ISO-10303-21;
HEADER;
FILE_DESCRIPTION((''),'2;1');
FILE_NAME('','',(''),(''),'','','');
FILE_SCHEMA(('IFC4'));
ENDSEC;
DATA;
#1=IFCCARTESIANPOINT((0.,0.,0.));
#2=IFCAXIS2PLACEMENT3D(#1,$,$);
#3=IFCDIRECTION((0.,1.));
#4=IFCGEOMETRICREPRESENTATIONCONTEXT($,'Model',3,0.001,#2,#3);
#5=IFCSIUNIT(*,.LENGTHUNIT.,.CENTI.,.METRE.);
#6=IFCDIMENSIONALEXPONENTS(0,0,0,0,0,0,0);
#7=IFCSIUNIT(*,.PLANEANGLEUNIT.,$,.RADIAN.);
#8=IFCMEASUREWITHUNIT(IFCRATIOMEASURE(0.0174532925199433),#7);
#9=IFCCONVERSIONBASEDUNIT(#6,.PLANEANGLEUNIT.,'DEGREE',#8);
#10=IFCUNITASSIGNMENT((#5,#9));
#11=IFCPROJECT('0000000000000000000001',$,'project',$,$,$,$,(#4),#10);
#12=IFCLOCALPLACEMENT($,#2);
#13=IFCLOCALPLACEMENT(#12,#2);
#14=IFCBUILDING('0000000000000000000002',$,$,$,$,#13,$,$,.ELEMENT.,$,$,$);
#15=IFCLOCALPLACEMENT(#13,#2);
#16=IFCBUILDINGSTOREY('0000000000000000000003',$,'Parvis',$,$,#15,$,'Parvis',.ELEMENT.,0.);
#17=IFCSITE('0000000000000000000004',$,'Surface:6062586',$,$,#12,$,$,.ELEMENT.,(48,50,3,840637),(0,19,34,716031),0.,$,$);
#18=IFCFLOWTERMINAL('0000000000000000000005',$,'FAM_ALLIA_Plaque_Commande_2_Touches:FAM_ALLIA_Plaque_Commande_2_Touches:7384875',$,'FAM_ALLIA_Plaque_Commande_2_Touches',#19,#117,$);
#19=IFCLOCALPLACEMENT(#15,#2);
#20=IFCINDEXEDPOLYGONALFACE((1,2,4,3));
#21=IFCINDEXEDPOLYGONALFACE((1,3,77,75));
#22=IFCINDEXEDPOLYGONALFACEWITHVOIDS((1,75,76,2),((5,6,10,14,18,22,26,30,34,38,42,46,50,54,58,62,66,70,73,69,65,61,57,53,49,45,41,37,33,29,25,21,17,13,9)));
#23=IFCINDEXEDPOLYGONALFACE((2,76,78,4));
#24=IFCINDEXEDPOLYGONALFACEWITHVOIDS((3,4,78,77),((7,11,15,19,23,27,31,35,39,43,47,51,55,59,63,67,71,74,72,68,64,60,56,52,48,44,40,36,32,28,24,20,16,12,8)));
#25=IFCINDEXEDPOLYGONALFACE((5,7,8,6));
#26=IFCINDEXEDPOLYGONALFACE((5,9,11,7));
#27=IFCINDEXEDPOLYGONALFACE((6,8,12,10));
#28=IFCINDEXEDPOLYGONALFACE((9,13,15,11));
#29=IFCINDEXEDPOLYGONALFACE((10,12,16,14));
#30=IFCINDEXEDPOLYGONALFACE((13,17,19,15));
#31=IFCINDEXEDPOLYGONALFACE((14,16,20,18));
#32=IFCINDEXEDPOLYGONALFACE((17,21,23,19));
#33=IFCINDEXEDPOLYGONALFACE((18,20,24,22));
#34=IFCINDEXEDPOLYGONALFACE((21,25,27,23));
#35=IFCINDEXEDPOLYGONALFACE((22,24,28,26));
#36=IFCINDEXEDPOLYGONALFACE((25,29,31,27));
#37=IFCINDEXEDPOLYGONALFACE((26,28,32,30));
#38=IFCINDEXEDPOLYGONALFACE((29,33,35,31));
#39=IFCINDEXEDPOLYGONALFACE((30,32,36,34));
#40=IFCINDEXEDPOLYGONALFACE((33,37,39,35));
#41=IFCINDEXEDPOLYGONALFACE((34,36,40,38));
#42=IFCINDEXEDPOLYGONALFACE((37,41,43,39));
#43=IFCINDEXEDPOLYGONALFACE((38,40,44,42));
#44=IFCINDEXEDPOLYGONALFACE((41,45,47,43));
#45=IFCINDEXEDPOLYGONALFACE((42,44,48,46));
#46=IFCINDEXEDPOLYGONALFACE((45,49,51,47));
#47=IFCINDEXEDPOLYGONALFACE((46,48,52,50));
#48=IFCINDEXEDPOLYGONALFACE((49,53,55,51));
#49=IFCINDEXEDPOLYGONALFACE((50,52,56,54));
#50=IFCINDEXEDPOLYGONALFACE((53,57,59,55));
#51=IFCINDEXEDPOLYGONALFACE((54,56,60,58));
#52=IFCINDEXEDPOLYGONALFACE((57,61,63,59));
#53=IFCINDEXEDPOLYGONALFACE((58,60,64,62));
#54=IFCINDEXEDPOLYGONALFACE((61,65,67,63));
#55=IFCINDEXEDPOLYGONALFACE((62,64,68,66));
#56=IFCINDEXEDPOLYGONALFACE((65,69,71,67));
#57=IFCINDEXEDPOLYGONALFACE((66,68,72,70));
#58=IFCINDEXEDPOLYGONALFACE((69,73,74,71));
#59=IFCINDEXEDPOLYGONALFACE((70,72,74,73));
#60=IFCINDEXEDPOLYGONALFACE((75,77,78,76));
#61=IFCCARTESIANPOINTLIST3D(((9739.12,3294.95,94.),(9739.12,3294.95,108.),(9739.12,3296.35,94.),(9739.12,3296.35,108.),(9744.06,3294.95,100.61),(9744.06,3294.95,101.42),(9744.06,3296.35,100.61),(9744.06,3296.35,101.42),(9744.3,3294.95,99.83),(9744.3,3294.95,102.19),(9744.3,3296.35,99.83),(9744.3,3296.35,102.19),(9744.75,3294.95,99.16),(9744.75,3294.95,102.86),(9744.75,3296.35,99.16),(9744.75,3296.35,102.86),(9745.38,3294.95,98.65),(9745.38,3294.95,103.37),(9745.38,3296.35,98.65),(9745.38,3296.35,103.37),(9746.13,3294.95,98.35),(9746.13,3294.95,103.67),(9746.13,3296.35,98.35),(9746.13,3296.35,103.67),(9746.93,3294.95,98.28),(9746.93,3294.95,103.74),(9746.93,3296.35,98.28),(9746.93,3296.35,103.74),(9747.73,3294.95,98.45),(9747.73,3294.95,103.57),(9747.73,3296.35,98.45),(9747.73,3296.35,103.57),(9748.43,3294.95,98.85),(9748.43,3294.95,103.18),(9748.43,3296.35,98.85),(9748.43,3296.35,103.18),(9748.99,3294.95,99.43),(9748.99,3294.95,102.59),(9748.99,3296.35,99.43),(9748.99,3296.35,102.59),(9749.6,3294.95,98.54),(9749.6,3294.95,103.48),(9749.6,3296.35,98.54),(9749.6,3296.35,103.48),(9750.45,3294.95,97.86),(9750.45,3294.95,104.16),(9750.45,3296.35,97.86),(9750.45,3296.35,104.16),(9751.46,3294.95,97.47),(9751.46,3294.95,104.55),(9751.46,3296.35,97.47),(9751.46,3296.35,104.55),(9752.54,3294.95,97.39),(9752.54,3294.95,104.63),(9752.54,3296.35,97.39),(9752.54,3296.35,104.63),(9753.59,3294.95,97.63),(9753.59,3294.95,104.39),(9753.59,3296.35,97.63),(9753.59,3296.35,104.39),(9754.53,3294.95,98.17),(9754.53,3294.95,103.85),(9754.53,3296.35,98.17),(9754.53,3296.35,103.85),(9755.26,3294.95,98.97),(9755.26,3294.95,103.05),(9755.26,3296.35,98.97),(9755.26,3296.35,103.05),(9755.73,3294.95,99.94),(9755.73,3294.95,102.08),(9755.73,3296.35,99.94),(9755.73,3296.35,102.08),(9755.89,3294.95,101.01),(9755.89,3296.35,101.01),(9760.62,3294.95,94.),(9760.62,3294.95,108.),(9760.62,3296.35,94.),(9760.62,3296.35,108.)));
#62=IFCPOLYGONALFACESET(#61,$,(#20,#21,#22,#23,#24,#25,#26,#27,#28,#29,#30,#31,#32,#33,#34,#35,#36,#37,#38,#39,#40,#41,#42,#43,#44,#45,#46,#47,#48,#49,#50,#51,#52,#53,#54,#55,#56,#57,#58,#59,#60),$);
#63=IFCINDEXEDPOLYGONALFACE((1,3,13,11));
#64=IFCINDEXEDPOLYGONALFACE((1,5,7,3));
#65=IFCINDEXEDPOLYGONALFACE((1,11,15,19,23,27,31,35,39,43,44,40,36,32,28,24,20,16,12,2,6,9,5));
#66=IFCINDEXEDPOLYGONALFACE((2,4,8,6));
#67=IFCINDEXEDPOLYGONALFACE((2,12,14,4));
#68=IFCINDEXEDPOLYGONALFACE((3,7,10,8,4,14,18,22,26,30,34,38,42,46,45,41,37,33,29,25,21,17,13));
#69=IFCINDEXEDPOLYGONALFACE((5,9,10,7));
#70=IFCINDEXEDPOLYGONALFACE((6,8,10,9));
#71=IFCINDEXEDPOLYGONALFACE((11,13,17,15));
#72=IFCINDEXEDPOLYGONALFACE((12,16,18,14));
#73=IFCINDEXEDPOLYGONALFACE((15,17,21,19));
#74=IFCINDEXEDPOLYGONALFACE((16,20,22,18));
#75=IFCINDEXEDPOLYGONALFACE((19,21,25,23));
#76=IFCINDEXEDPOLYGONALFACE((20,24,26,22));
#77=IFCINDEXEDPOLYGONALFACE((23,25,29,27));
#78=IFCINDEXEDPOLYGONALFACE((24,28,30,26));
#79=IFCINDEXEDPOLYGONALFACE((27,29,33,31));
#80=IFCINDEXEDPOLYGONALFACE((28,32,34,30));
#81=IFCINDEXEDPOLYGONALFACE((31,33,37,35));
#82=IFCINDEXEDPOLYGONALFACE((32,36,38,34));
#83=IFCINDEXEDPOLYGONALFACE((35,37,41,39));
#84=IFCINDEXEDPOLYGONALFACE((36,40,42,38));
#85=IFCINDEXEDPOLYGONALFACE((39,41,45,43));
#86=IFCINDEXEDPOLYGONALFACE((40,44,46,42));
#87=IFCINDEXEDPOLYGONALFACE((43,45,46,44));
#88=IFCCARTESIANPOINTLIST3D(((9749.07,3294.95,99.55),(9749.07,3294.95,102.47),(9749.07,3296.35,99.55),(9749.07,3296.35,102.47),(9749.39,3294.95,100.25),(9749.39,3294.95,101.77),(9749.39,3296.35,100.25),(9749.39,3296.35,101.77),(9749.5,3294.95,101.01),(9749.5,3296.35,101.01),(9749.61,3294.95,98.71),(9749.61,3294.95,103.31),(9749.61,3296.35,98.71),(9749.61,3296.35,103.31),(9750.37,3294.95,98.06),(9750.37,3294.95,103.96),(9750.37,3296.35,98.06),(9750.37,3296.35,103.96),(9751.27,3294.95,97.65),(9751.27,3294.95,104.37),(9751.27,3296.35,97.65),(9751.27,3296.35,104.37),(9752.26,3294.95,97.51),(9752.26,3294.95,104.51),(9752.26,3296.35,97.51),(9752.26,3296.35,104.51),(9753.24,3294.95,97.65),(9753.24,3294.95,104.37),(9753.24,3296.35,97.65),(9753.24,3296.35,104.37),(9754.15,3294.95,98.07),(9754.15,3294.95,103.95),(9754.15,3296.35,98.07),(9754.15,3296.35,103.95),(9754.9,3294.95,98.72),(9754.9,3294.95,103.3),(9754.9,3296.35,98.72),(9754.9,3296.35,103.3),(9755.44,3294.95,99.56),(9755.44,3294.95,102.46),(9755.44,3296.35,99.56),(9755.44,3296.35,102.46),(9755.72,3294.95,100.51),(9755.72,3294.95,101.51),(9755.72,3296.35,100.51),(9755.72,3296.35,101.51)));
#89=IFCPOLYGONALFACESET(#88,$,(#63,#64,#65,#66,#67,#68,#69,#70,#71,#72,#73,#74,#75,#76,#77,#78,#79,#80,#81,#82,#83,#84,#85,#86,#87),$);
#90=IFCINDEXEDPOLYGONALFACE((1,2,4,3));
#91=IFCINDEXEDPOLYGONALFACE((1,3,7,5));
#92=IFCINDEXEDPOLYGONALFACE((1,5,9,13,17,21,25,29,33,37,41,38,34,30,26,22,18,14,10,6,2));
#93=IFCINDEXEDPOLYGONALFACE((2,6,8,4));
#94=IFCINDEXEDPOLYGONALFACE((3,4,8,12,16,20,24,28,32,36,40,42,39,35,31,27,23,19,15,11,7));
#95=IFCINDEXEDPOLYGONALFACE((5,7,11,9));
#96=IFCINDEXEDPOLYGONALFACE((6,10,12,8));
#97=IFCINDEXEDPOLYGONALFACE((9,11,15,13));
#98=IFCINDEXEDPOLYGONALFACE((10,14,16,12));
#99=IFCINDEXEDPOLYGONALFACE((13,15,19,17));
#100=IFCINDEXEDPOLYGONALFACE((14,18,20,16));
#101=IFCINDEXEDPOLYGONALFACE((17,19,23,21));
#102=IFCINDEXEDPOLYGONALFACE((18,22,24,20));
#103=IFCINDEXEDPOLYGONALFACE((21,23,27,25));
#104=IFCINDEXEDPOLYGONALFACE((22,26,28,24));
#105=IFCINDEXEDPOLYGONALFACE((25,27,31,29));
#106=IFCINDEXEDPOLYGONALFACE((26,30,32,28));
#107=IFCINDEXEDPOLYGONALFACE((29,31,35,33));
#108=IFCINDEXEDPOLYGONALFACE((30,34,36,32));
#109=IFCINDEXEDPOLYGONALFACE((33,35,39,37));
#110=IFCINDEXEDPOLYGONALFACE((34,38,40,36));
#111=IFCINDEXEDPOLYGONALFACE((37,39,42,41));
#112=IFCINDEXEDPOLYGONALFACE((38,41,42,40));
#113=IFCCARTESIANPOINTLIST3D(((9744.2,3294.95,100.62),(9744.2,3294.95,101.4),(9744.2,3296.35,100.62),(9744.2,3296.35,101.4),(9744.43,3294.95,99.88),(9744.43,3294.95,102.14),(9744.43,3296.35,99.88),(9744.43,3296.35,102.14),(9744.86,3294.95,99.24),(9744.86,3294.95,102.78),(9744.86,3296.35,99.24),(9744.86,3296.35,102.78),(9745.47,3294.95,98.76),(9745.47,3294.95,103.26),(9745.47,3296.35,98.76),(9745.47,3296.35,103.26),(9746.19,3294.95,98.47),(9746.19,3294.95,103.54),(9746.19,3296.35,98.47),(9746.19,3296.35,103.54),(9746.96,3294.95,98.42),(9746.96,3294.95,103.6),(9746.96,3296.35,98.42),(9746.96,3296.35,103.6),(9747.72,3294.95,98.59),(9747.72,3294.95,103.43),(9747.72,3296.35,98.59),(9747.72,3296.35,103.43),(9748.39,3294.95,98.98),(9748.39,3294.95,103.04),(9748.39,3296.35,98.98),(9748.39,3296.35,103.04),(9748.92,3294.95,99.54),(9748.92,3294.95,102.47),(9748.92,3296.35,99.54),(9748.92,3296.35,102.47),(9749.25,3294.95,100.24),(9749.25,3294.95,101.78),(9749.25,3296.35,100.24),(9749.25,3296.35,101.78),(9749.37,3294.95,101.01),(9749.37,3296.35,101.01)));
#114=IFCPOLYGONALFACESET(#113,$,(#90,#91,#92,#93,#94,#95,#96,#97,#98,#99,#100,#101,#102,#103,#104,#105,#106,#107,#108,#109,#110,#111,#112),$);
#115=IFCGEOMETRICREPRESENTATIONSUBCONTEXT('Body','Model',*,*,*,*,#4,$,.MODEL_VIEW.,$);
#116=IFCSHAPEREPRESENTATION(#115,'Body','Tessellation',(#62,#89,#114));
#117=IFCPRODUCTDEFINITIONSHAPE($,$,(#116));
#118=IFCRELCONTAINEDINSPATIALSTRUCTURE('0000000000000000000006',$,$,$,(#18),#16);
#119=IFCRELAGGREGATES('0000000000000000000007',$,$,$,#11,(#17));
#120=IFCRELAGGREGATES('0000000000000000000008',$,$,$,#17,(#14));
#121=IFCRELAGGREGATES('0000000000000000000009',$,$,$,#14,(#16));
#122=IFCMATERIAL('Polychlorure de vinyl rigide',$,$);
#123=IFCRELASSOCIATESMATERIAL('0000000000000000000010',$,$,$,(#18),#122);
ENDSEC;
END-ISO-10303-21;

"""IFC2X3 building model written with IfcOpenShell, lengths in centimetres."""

from ifc_helpers import new_model, entity, si_unit, converted_unit, direction, frame, frame_2d, origin, place, context, subcontext, project, spatial, polyline, circle_curve, parameter, trimmed, segment, composite_curve, circle, outline, extrude, source, transform, mapped, material, element, save


model = new_model("IFC2X3")

# Units and contexts
model_context = context("Model", 3, precision=0.001, world=origin(), true_north=direction((0.0, 1.0)))
body_context = subcontext(model_context, "Body", "Model", "MODEL_VIEW")
ifc_project = project(units=[si_unit("LENGTHUNIT", "METRE", prefix="CENTI"), converted_unit("PLANEANGLEUNIT", "DEGREE", entity("IfcRatioMeasure", 0.0174532925199433), si_unit("PLANEANGLEUNIT", "RADIAN"), dimensions=[0, 0, 0, 0, 0, 0, 0])], contexts=[model_context])

# Site, building, storey
site_placement = place(None, origin())
site = spatial("IfcSite", under=ifc_project, at=site_placement, Name="Surface:6062586", CompositionType="ELEMENT", RefLatitude=(48, 50, 3, 840637), RefLongitude=(0, 19, 34, 716031), RefElevation=0.0)
building_placement = place(site_placement, origin())
building = spatial("IfcBuilding", under=site, at=building_placement, CompositionType="ELEMENT")
storey_placement = place(building_placement, frame((0.0, 0.0, 0.0)))
storey = spatial("IfcBuildingStorey", under=building, at=storey_placement, Name="Parvis", LongName="Parvis", CompositionType="ELEMENT", Elevation=0.0)

# Flow terminal
ifc_material_1 = material(Name="Polychlorure de vinyl rigide")
shared_shape_1 = source(origin(), body_context, "Body", "SweptSolid", [
    extrude(outline(polyline([(-10.75, -7.0), (10.75, -7.0), (10.75, 7.0), (-10.75, 7.0), (-10.75, -7.0)]), holes=[composite_curve([segment(trimmed(circle_curve(frame_2d((-3.1, 0.01), x_axis=(-1.0, 0.0)), 2.73), [parameter(215.328783)], [parameter(144.671217)], True, "PARAMETER"), False, "CONTINUOUS"), segment(trimmed(circle_curve(frame_2d((2.39, 0.01), x_axis=(-1.0, 0.0)), 3.63), [parameter(25.817037)], [parameter(334.182963)], True, "PARAMETER"), False, "CONTINUOUS")], self_intersect=False)]), frame((10.75, 0.0, 7.0), z_axis=(0.0, 1.0, 0.0), x_axis=(-1.0, 0.0, 0.0)), (0.0, 0.0, 1.0), 1.4),
    extrude(outline(composite_curve([segment(trimmed(circle_curve(frame_2d((-3.18, 0.0), x_axis=(1.0, 0.0)), 3.5), [parameter(24.630749)], [parameter(335.341392)], True, "PARAMETER"), True, "CONTINUOUS"), segment(trimmed(circle_curve(frame_2d((2.31, 0.0), x_axis=(1.0, 0.0)), 2.73), [parameter(147.719336)], [parameter(212.252805)], True, "PARAMETER"), False, "CONTINUOUS")], self_intersect=False)), frame((11.54, 0.0, 7.01), z_axis=(0.0, 1.0, 0.0), x_axis=(1.0, 0.0, 0.0)), (0.0, 0.0, 1.0), 1.4),
    extrude(circle(Radius=2.6, at=frame_2d((0.0, 0.0), x_axis=(1.0, 0.0))), frame((13.85, 0.0, 7.01), z_axis=(0.0, 1.0, 0.0), x_axis=(-1.0, 0.0, 0.0)), (0.0, 0.0, 1.0), 1.4),
])
for number, where, z_axis, x_axis, name in (
    (1, (9760.62, 3296.35, 94.0), (0.0, 0.0, 1.0), (-1.0, 0.0, 0.0), "FAM_ALLIA_Plaque_Commande_2_Touches:FAM_ALLIA_Plaque_Commande_2_Touches:7384875"),
):
    element("IfcFlowTerminal", number, at=place(storey_placement, frame(where, z_axis=z_axis, x_axis=x_axis)), inside=storey, material=ifc_material_1, Name=name, ObjectType="FAM_ALLIA_Plaque_Commande_2_Touches", context=body_context, shape_type="MappedRepresentation", body=[
        mapped(shared_shape_1, transform((0.0, 0.0, 0.0), scale=1.0)),
    ])

save(model, "model.ifc")
